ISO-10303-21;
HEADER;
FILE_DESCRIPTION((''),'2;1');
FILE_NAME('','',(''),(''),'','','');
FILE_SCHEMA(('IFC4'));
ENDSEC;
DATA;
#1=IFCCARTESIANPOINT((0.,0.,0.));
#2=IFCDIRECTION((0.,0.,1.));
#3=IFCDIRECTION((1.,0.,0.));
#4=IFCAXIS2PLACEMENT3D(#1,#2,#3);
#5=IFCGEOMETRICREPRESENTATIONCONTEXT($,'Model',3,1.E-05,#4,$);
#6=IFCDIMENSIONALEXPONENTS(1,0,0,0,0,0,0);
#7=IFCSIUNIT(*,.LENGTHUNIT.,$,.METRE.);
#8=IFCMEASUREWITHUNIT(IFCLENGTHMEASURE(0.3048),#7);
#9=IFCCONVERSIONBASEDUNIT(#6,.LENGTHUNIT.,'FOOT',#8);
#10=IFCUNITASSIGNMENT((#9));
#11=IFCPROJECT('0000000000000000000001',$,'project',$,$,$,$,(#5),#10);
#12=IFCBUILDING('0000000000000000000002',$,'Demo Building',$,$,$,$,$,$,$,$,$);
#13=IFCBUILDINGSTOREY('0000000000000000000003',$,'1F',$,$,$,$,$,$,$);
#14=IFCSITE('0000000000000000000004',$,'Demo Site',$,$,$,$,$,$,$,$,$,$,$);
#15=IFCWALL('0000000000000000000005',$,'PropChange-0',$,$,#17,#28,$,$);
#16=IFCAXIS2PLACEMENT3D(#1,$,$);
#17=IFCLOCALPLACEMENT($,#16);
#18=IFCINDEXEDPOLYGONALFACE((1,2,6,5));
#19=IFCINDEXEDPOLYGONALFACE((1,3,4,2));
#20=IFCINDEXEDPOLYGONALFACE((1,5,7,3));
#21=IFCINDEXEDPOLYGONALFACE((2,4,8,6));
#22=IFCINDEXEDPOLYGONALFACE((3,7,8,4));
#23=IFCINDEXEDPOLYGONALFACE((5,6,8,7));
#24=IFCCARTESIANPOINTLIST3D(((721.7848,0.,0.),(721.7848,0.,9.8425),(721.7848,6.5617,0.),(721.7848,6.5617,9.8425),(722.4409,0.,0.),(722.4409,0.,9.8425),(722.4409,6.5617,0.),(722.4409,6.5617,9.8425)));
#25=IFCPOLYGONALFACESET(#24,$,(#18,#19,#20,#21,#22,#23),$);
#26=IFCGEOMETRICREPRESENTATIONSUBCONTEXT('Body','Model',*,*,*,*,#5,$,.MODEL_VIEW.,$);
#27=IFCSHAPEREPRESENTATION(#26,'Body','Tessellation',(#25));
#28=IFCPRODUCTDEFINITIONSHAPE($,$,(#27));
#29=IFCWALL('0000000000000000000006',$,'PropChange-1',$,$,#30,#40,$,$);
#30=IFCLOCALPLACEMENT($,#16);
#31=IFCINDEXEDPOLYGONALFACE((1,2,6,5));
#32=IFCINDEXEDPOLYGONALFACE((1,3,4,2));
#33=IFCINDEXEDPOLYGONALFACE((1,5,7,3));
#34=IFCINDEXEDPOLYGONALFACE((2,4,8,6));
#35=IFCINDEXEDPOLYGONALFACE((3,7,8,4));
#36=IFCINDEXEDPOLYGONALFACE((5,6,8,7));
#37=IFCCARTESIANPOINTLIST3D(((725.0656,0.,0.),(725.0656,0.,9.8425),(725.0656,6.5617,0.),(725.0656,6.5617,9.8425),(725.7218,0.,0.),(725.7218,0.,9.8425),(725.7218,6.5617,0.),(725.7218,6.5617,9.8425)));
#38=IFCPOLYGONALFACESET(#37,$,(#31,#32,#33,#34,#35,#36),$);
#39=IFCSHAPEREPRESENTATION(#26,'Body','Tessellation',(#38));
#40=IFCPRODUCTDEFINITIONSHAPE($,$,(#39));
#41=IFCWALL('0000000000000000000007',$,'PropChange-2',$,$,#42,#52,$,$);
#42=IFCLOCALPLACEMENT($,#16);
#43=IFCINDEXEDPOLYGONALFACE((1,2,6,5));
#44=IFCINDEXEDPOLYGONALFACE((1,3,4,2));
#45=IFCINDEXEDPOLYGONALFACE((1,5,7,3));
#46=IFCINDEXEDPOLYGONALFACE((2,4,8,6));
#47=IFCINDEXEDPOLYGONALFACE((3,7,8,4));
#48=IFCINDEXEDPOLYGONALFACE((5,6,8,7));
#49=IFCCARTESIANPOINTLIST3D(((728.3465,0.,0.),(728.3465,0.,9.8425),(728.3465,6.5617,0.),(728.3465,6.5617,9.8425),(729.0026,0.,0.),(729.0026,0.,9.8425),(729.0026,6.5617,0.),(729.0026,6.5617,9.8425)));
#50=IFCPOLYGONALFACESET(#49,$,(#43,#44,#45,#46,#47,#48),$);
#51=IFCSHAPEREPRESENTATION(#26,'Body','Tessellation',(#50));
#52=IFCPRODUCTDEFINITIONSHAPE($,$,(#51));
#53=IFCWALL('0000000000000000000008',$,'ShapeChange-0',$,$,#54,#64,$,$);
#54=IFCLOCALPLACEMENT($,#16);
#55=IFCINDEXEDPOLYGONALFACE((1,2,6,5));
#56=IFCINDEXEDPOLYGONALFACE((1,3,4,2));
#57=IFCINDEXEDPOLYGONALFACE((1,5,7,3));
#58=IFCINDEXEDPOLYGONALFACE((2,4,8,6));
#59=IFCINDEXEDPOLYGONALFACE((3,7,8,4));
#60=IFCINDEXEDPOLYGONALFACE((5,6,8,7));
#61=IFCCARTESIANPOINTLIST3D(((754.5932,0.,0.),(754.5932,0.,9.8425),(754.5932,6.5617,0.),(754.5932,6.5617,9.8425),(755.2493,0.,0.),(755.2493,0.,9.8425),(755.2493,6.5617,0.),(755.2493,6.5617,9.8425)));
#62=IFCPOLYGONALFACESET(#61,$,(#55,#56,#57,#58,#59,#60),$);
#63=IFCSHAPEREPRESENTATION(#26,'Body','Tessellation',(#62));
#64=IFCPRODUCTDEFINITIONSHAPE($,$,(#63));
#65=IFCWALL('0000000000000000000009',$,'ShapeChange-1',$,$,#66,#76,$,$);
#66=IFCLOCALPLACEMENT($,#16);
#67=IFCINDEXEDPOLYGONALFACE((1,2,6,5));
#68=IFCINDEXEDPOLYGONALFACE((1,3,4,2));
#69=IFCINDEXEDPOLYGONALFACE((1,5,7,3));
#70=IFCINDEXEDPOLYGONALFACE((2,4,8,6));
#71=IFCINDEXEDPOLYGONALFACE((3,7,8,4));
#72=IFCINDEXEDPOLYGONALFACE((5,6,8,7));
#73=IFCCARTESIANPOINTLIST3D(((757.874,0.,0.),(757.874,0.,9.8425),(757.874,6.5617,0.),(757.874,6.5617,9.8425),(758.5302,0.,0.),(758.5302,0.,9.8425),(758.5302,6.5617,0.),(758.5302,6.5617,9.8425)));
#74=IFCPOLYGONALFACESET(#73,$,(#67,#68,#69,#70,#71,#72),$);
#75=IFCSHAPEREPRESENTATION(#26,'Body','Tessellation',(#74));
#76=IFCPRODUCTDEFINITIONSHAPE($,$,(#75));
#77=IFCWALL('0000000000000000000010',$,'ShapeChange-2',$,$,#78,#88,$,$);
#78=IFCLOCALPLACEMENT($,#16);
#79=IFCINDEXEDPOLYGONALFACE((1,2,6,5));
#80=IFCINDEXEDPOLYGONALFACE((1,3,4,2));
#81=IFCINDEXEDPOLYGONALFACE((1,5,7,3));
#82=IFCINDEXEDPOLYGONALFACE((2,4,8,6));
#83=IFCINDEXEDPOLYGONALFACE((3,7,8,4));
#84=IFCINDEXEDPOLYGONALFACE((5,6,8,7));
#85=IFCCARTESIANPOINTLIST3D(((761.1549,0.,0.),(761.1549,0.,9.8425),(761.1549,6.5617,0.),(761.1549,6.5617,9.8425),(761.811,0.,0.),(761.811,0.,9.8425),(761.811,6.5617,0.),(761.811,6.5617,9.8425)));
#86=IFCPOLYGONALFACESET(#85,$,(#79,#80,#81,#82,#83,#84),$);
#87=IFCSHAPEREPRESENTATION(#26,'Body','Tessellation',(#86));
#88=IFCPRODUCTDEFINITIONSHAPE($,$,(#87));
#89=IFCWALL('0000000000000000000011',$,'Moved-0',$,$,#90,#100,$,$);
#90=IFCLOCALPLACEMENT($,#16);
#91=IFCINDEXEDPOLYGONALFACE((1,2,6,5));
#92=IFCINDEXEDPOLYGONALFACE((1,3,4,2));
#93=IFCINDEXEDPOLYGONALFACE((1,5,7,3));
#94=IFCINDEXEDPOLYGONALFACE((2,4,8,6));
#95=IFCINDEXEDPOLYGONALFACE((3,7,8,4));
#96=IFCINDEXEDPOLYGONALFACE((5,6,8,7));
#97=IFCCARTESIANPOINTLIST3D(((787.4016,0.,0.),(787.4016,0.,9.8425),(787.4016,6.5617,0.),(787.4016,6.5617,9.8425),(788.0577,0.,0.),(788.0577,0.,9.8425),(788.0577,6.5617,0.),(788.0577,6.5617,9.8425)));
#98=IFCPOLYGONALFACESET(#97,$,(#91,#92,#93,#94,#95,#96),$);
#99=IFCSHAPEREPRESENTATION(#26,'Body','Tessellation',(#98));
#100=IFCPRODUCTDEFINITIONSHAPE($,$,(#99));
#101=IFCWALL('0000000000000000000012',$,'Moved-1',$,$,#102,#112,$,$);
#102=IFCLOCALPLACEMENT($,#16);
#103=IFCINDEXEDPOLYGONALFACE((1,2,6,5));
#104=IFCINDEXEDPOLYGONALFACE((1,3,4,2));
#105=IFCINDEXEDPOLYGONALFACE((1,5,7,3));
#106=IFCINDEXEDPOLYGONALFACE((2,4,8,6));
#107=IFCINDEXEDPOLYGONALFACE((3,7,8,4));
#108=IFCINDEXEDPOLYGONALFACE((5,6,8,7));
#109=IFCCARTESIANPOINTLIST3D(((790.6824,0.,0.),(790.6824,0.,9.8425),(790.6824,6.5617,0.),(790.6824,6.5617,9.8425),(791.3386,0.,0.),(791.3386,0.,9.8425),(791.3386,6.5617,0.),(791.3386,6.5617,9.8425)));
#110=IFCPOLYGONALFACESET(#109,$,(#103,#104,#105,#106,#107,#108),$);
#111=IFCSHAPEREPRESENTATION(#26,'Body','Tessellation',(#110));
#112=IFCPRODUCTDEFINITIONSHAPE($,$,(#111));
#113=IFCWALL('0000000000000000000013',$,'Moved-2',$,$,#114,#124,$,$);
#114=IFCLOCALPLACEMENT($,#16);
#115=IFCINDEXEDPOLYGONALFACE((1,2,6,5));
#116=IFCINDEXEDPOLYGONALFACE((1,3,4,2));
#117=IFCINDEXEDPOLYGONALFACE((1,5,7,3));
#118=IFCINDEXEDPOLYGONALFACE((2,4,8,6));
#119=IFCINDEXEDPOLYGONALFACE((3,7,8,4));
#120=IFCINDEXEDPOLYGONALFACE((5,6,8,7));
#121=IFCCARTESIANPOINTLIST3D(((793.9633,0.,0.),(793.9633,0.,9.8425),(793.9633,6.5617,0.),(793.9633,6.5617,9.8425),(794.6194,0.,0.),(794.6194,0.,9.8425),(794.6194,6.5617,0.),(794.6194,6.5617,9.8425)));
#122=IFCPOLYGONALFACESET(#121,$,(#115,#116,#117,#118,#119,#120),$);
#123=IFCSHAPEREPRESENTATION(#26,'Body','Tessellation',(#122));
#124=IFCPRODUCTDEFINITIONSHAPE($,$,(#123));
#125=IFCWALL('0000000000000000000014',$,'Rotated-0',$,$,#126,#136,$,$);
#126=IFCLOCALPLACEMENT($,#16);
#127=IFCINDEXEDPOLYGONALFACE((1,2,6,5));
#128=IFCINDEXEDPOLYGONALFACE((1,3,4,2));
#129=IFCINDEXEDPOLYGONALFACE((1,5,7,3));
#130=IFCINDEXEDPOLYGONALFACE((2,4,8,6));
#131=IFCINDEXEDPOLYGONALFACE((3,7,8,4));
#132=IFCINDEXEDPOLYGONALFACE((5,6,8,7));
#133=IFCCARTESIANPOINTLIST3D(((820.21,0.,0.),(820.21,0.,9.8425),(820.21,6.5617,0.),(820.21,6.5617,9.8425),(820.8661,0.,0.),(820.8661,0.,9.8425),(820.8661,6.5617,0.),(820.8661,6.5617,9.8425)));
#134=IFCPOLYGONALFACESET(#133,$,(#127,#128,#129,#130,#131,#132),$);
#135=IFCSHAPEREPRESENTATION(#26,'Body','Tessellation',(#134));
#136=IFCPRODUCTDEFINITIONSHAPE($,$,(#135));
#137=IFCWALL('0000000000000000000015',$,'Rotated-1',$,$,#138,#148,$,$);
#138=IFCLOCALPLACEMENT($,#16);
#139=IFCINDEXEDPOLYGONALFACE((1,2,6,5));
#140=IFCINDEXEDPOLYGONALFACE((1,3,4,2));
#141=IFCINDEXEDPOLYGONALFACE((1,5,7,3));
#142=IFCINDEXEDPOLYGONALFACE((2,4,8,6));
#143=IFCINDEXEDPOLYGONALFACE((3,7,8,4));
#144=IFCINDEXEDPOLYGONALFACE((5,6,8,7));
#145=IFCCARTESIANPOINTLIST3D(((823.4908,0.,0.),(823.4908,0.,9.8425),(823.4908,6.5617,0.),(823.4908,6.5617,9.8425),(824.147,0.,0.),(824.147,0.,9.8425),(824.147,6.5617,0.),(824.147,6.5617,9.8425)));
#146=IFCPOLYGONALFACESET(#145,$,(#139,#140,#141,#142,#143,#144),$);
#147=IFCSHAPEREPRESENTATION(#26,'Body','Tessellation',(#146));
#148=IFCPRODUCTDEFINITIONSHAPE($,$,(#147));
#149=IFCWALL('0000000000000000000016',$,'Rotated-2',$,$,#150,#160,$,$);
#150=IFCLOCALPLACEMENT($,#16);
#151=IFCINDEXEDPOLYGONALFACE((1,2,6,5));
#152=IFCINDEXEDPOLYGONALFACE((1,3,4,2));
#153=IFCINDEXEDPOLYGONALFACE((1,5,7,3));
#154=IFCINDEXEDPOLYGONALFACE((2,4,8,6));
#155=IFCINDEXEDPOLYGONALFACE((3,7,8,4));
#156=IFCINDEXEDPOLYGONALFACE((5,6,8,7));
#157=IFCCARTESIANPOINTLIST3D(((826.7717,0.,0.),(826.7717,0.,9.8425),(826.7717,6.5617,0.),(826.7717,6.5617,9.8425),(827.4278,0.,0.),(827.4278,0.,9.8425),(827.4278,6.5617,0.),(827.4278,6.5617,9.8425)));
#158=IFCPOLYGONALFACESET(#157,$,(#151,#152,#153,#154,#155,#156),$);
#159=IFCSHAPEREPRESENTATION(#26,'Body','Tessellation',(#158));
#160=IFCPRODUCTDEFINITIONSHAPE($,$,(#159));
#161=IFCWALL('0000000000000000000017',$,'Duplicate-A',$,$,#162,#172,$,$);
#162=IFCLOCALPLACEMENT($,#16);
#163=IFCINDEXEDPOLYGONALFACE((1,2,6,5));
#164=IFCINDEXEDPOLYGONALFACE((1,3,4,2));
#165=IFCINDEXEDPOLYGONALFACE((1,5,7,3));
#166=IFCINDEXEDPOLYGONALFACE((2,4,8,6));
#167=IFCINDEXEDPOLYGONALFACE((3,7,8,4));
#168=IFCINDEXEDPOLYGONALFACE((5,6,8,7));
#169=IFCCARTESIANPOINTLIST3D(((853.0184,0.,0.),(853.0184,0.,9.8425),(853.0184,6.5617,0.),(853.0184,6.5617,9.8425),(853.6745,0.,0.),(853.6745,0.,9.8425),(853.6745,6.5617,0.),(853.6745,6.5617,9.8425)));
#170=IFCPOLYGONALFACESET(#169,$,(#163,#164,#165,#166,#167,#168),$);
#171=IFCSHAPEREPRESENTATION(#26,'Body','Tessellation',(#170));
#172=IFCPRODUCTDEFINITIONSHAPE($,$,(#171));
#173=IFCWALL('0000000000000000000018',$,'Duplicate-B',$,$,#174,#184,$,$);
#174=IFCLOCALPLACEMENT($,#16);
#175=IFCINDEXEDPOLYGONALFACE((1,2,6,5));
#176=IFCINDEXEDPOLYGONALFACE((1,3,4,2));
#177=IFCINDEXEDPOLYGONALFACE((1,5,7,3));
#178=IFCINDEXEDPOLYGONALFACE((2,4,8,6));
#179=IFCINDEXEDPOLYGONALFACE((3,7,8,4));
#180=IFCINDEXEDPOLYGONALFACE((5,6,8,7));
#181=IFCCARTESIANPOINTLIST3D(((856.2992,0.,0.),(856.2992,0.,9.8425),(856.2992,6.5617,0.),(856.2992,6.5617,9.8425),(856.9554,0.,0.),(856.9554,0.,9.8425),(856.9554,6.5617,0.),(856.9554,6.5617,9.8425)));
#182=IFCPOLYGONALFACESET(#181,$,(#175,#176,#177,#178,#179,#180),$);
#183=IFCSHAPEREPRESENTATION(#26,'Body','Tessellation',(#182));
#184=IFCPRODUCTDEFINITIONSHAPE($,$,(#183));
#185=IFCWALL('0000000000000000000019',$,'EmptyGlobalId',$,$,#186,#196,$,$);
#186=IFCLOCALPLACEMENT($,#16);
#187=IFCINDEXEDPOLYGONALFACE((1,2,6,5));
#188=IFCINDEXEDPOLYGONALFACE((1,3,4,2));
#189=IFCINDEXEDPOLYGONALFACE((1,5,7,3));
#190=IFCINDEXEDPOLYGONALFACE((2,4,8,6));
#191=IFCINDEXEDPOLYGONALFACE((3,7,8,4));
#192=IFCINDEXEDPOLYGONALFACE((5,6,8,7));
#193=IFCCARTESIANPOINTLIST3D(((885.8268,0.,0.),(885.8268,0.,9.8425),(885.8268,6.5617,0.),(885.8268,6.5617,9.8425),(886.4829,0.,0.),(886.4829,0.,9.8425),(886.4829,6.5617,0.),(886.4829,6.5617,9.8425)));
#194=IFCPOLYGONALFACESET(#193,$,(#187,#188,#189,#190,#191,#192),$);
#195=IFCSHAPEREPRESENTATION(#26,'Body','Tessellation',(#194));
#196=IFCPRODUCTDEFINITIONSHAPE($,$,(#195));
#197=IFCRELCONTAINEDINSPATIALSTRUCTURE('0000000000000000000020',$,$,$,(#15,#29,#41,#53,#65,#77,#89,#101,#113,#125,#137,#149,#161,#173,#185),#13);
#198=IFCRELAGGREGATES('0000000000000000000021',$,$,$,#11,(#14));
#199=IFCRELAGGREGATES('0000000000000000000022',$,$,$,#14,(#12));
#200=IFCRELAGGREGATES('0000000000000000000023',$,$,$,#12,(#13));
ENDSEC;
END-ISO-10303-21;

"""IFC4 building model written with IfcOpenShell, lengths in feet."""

from ifc_helpers import new_model, entity, si_unit, converted_unit, frame, origin_with_axes, place, context, subcontext, project, spatial, element, save


model = new_model("IFC4")

# Units and contexts
model_context = context("Model", 3, precision=1e-05, world=origin_with_axes())
body_context = subcontext(model_context, "Body", "Model", "MODEL_VIEW")
ifc_project = project(units=[converted_unit("LENGTHUNIT", "FOOT", entity("IfcLengthMeasure", 0.3048), si_unit("LENGTHUNIT", "METRE"), dimensions=[1, 0, 0, 0, 0, 0, 0])], contexts=[model_context])

# Site, building, storey
site = spatial("IfcSite", under=ifc_project, Name="Demo Site")
building = spatial("IfcBuilding", under=site, Name="Demo Building")
storey = spatial("IfcBuildingStorey", under=building, Name="1F")

# Walls
for number, where, z_axis, x_axis, name in (
    (1, (721.7848, 0.0, 0.0), (0.0, 0.0, 1.0), (1.0, 0.0, 0.0), "PropChange-0"),
    (2, (725.0656, 0.0, 0.0), (0.0, 0.0, 1.0), (1.0, 0.0, 0.0), "PropChange-1"),
    (3, (728.3465, 0.0, 0.0), (0.0, 0.0, 1.0), (1.0, 0.0, 0.0), "PropChange-2"),
    (4, (754.5932, 0.0, 0.0), (0.0, 0.0, 1.0), (1.0, 0.0, 0.0), "ShapeChange-0"),
    (5, (757.874, 0.0, 0.0), (0.0, 0.0, 1.0), (1.0, 0.0, 0.0), "ShapeChange-1"),
    (6, (761.1549, 0.0, 0.0), (0.0, 0.0, 1.0), (1.0, 0.0, 0.0), "ShapeChange-2"),
    (7, (787.4016, 0.0, 0.0), (0.0, 0.0, 1.0), (1.0, 0.0, 0.0), "Moved-0"),
    (8, (790.6824, 0.0, 0.0), (0.0, 0.0, 1.0), (1.0, 0.0, 0.0), "Moved-1"),
    (9, (793.9633, 0.0, 0.0), (0.0, 0.0, 1.0), (1.0, 0.0, 0.0), "Moved-2"),
    (10, (820.21, 0.0, 0.0), (0.0, 0.0, 1.0), (1.0, 0.0, 0.0), "Rotated-0"),
    (11, (823.4908, 0.0, 0.0), (0.0, 0.0, 1.0), (1.0, 0.0, 0.0), "Rotated-1"),
    (12, (826.7717, 0.0, 0.0), (0.0, 0.0, 1.0), (1.0, 0.0, 0.0), "Rotated-2"),
    (13, (853.0184, 0.0, 0.0), (0.0, 0.0, 1.0), (1.0, 0.0, 0.0), "Duplicate-A"),
    (14, (856.2992, 0.0, 0.0), (0.0, 0.0, 1.0), (1.0, 0.0, 0.0), "Duplicate-B"),
    (15, (885.8268, 0.0, 0.0), (0.0, 0.0, 1.0), (1.0, 0.0, 0.0), "EmptyGlobalId"),
):
    element("IfcWall", number, at=place(None, frame(where, z_axis=z_axis, x_axis=x_axis)), inside=storey, Name=name, context=body_context, shape_type="CSG", body=[
        entity("IfcBlock", entity("IfcAxis2Placement3D", entity("IfcCartesianPoint", [0.0, 0.0, 0.0]), entity("IfcDirection", [0.0, 0.0, 1.0]), entity("IfcDirection", [1.0, 0.0, 0.0])), 0.6562, 6.5617, 9.8425),
    ])

save(model, "model.ifc")
